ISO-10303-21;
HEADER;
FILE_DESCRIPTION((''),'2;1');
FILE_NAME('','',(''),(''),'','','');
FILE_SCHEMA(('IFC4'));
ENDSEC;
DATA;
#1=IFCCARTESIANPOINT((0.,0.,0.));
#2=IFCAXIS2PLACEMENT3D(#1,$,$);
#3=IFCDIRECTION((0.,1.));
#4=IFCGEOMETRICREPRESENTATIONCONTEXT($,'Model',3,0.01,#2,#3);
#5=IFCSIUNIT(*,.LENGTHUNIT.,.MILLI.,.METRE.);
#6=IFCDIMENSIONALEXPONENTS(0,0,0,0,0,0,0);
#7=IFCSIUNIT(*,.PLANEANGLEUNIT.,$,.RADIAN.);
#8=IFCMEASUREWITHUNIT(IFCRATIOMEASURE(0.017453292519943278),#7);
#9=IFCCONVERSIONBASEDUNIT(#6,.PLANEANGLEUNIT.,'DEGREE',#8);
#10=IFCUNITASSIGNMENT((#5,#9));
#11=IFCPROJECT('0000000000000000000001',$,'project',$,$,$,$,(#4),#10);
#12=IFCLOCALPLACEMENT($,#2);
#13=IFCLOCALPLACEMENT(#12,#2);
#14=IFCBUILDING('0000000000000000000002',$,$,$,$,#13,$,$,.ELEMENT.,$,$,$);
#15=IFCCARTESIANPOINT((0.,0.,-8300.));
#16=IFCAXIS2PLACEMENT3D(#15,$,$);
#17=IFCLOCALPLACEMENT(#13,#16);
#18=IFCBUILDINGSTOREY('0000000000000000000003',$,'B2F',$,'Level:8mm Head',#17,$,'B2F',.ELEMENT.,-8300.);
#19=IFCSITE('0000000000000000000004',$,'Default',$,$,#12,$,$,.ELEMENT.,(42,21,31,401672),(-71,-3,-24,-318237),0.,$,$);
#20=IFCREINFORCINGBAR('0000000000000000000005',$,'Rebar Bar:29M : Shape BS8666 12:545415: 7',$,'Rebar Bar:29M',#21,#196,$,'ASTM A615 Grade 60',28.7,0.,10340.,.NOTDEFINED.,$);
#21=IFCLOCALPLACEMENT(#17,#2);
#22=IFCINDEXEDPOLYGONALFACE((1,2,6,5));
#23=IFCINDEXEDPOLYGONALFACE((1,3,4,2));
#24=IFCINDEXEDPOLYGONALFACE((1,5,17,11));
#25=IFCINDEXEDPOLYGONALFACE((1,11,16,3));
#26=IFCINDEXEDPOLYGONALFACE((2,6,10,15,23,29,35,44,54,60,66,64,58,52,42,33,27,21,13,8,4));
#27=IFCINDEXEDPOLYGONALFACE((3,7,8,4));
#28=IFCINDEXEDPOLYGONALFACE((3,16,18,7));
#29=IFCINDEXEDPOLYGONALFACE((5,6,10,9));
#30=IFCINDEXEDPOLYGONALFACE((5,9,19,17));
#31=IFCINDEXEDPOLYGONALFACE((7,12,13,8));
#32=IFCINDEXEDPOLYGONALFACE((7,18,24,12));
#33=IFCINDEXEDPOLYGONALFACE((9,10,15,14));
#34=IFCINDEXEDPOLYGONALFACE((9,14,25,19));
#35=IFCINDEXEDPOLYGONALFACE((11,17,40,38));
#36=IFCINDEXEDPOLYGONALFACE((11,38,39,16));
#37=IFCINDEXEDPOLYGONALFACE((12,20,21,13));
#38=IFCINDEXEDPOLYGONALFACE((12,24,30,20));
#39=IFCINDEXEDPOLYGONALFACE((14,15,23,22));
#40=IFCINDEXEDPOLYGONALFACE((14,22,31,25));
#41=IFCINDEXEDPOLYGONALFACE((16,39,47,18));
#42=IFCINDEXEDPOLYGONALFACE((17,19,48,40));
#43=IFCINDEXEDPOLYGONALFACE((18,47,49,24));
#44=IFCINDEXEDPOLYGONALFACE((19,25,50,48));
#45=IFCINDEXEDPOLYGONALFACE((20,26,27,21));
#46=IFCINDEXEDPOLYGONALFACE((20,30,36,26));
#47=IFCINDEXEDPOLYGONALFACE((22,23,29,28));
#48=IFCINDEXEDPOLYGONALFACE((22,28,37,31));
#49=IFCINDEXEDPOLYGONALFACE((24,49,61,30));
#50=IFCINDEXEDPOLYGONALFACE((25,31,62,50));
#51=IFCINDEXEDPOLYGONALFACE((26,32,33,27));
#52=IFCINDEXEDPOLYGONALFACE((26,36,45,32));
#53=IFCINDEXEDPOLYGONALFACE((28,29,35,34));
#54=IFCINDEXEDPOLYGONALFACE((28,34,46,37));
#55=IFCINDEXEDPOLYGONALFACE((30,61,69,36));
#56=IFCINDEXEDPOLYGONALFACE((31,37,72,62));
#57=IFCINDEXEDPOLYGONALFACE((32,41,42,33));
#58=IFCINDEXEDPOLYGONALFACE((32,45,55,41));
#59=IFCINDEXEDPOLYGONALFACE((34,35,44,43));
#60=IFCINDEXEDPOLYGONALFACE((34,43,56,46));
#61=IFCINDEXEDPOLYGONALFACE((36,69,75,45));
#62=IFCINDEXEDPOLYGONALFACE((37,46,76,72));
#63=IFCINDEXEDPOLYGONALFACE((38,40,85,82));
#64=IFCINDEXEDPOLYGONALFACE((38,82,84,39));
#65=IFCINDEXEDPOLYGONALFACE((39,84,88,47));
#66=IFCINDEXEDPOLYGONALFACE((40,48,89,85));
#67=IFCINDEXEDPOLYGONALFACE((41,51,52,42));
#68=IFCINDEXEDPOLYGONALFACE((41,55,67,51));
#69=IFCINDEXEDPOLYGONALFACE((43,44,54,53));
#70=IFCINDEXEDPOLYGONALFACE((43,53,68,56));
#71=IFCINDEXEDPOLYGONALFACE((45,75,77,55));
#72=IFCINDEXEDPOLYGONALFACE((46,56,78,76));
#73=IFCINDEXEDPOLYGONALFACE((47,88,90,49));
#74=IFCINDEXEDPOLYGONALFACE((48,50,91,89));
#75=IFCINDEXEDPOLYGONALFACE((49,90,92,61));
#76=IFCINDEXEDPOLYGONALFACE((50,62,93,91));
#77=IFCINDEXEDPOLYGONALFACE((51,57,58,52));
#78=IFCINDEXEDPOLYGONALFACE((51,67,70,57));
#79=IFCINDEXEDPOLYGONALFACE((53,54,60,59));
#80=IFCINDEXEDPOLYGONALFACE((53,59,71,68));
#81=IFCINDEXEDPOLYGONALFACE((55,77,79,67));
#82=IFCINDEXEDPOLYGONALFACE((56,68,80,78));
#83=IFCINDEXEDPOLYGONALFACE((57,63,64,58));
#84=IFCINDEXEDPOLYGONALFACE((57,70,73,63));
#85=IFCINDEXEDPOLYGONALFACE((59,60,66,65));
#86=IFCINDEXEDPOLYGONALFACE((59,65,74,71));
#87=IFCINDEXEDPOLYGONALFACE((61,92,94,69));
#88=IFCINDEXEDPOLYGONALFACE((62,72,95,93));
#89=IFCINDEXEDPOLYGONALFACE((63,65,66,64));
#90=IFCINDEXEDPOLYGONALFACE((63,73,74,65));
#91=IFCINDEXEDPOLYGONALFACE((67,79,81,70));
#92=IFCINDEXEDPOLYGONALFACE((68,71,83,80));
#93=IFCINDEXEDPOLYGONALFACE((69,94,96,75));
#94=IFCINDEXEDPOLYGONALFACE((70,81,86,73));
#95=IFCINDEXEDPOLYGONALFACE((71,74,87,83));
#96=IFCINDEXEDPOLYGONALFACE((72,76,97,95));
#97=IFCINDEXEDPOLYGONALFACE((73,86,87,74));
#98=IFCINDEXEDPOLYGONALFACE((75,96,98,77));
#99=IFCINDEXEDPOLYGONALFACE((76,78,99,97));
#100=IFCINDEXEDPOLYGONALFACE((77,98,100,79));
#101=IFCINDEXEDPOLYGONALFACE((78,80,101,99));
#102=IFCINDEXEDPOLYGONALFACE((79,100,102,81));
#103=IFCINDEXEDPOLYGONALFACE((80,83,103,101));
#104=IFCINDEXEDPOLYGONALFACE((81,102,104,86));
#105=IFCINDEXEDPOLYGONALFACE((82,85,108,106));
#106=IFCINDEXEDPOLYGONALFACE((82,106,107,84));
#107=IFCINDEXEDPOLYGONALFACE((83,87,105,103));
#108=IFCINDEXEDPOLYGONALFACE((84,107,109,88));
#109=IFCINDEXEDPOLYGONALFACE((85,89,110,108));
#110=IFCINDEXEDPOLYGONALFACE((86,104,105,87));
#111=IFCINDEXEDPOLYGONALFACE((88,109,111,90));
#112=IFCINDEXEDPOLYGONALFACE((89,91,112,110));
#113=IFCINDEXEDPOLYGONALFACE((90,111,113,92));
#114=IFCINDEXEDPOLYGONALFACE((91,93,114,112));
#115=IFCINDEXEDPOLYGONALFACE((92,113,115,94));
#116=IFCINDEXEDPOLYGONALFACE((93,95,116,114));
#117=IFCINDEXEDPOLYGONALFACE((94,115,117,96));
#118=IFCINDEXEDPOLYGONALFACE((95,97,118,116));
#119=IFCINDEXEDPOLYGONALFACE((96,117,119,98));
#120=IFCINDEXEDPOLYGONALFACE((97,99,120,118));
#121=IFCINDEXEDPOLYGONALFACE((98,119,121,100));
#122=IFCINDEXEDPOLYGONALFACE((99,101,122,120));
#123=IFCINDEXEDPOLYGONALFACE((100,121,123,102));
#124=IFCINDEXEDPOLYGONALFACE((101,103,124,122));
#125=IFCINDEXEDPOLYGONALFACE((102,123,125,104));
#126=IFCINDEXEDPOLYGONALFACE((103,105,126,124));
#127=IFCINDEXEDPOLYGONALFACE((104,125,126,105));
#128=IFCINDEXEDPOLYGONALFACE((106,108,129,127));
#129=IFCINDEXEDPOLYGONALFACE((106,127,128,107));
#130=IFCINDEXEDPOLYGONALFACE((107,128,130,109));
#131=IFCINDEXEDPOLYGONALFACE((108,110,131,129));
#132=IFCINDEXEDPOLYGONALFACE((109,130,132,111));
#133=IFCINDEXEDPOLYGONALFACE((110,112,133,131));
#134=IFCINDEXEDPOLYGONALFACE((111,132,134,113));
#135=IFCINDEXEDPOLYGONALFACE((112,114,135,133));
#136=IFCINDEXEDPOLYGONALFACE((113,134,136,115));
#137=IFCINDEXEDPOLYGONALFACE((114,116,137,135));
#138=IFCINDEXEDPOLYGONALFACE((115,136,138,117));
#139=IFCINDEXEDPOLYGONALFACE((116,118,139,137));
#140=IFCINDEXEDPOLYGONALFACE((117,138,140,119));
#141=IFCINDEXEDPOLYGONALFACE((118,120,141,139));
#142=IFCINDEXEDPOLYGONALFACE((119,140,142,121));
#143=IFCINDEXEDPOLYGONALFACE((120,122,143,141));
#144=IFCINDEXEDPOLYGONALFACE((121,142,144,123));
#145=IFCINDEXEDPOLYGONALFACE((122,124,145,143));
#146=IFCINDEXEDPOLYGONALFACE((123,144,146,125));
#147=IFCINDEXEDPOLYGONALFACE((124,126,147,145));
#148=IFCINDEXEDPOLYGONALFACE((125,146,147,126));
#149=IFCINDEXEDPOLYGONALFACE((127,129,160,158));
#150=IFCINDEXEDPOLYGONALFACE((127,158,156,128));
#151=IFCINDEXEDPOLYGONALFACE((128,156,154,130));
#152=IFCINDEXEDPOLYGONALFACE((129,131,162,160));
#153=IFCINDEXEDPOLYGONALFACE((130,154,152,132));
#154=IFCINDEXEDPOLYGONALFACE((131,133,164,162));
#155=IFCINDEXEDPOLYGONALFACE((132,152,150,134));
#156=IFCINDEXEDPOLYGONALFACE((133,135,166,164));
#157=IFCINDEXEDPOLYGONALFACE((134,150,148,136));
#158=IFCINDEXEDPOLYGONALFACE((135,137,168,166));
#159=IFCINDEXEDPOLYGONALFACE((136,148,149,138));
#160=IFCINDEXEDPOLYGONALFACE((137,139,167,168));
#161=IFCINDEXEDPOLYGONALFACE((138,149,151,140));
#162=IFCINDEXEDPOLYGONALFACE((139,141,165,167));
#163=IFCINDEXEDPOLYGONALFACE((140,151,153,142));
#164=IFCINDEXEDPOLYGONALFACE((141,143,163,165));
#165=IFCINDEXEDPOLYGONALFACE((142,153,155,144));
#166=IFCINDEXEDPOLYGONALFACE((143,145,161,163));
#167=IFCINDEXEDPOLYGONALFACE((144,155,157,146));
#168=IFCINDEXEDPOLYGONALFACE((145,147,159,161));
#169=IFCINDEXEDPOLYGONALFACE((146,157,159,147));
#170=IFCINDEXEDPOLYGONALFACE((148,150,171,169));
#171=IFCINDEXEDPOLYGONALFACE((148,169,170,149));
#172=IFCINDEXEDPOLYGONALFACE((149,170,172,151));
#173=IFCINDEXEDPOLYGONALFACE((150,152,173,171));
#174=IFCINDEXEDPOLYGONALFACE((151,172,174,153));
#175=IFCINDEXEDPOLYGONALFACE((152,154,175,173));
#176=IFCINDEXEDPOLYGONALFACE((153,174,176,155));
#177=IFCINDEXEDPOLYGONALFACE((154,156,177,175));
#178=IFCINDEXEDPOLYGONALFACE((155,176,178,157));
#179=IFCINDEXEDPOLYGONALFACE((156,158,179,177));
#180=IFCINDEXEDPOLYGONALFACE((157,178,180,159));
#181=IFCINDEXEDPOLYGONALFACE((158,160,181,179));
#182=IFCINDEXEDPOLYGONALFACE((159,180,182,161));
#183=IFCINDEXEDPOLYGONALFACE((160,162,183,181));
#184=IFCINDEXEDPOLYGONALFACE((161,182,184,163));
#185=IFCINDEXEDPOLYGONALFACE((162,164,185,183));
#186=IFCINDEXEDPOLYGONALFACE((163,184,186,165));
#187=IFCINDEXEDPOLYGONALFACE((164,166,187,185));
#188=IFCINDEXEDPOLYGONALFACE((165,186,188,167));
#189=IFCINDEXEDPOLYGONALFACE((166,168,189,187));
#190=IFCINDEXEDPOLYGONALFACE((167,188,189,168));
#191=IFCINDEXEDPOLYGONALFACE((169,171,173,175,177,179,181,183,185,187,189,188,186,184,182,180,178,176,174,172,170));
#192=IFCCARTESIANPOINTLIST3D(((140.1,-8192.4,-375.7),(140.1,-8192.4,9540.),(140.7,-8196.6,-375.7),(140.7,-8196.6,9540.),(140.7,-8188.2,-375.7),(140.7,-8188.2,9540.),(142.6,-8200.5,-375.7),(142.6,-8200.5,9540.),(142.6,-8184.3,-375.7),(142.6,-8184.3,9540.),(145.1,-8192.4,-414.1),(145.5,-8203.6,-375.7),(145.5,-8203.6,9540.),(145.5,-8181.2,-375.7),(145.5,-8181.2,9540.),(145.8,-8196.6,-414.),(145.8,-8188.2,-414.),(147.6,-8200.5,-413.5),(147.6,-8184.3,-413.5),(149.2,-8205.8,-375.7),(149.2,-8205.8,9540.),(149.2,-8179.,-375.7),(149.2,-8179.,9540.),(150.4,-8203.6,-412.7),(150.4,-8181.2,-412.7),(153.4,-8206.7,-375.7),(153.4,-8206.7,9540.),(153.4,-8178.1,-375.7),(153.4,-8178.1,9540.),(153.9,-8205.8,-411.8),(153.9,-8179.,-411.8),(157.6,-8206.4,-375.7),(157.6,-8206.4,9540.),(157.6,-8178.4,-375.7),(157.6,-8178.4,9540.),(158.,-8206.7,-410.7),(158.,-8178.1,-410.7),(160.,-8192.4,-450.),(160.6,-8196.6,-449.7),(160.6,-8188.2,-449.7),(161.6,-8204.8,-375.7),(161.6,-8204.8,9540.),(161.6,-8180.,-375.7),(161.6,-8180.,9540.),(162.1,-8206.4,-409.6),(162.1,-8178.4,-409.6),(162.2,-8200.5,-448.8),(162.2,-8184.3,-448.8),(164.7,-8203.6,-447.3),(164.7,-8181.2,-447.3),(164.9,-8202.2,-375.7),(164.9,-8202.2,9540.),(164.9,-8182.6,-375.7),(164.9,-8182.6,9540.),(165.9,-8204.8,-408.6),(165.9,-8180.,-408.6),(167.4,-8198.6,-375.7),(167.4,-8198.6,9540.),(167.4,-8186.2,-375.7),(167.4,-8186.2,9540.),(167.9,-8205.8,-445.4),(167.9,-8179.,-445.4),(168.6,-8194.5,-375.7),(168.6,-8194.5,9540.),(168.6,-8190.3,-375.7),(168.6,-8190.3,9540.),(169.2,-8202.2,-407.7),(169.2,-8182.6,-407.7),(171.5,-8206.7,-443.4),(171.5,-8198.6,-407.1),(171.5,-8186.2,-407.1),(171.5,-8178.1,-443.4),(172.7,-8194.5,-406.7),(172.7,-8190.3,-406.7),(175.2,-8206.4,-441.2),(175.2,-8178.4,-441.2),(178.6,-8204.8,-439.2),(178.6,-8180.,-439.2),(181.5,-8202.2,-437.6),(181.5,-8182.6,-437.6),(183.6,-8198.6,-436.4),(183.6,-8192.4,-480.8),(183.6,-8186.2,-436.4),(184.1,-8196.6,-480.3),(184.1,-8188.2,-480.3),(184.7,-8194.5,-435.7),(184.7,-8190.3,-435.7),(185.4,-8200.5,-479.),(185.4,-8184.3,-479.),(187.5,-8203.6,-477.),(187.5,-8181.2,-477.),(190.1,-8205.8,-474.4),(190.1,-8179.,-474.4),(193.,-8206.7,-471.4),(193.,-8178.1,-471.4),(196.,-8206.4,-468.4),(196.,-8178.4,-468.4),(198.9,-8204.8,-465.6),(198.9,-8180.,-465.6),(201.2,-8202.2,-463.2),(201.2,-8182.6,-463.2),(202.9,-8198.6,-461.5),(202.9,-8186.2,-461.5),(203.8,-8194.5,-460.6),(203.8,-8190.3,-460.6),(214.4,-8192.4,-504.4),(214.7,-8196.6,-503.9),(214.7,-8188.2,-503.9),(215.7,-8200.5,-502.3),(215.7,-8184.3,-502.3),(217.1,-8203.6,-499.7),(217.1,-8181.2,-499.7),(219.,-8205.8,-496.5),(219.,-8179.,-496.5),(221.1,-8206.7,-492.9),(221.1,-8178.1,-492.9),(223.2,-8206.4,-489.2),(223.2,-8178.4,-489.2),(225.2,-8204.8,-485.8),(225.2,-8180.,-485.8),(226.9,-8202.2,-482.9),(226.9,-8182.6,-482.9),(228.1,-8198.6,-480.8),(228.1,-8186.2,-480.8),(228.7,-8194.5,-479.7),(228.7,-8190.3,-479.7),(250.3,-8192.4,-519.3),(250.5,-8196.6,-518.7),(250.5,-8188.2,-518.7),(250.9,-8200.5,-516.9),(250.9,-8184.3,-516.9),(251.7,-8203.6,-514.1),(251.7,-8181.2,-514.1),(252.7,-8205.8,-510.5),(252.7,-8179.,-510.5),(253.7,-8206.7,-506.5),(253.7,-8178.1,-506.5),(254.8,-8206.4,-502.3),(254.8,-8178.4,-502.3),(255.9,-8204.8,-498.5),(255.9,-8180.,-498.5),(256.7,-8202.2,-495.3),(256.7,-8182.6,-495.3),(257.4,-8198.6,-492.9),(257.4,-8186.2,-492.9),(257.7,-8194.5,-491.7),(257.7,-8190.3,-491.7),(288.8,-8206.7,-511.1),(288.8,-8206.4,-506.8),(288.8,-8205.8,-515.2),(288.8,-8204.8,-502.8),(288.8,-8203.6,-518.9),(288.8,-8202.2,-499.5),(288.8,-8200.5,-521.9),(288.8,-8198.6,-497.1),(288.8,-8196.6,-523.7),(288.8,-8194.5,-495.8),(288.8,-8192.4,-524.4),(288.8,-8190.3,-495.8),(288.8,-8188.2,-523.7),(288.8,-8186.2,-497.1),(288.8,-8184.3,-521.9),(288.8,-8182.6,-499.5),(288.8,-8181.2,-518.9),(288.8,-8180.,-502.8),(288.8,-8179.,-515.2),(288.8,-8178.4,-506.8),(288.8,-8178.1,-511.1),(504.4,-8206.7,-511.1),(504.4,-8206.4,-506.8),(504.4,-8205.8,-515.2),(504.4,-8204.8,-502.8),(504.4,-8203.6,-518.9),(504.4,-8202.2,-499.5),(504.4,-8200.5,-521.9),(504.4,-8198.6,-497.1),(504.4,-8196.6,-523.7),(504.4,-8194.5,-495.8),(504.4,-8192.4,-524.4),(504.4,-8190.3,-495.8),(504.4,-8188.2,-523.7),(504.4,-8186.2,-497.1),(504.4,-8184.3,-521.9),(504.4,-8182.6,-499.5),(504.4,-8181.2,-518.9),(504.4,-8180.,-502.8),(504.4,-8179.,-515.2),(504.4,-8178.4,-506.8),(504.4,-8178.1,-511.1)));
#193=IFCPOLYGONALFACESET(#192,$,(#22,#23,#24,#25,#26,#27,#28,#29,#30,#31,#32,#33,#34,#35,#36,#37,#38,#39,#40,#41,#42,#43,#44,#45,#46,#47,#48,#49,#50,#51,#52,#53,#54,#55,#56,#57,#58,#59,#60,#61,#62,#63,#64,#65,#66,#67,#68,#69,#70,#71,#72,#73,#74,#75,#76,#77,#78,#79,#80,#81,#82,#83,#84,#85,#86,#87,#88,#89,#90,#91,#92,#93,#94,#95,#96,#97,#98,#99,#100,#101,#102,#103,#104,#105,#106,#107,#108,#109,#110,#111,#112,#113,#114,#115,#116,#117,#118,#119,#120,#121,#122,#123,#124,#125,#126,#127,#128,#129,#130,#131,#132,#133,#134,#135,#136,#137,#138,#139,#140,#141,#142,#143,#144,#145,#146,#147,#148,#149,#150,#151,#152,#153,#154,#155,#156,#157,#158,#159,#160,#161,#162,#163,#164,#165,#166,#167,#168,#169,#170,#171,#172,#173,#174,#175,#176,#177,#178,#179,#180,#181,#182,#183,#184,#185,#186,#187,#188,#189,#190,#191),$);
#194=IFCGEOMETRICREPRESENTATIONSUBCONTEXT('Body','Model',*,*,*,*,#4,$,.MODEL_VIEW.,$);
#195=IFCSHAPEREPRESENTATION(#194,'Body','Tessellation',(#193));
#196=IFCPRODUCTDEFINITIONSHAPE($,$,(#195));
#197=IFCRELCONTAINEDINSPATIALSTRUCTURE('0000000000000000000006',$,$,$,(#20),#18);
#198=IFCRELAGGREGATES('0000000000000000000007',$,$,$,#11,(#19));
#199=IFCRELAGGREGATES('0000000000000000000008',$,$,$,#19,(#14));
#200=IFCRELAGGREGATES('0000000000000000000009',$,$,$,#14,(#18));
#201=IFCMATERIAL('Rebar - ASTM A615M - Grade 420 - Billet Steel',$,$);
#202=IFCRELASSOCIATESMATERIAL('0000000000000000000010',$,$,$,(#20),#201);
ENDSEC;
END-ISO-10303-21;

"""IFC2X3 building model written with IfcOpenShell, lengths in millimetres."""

from ifc_helpers import new_model, entity, si_unit, converted_unit, direction, frame, origin, place, context, subcontext, project, spatial, material, element, save


model = new_model("IFC2X3")

# Units and contexts
model_context = context("Model", 3, precision=0.01, world=origin(), true_north=direction((0.0, 1.0)))
body_context = subcontext(model_context, "Body", "Model", "MODEL_VIEW")
ifc_project = project(units=[si_unit("LENGTHUNIT", "METRE", prefix="MILLI"), converted_unit("PLANEANGLEUNIT", "DEGREE", entity("IfcRatioMeasure", 0.017453292519943278), si_unit("PLANEANGLEUNIT", "RADIAN"), dimensions=[0, 0, 0, 0, 0, 0, 0])], contexts=[model_context])

# Site, building, storey
site_placement = place(None, origin())
site = spatial("IfcSite", under=ifc_project, at=site_placement, Name="Default", CompositionType="ELEMENT", RefLatitude=(42, 21, 31, 401672), RefLongitude=(-71, -3, -24, -318237), RefElevation=0.0)
building_placement = place(site_placement, origin())
building = spatial("IfcBuilding", under=site, at=building_placement, CompositionType="ELEMENT")
storey_placement = place(building_placement, frame((0.0, 0.0, -8300.0)))
storey = spatial("IfcBuildingStorey", under=building, at=storey_placement, Name="B2F", ObjectType="Level:8mm Head", LongName="B2F", CompositionType="ELEMENT", Elevation=-8300.0)

# Reinforcing bar
ifc_material_1 = material(Name="Rebar - ASTM A615M - Grade 420 - Billet Steel")
reinforcing_bar_1_placement = place(storey_placement, origin())
element("IfcReinforcingBar", 1, at=reinforcing_bar_1_placement, inside=storey, material=ifc_material_1, Name="Rebar Bar:29M : Shape BS8666 12:545415: 7", SteelGrade="ASTM A615 Grade 60", ObjectType="Rebar Bar:29M", BarLength=10340.0, BarRole="NOTDEFINED", CrossSectionArea=0.0, NominalDiameter=28.7, context=body_context, shape_type="AdvancedSweptSolid", body=[
    entity("IfcSweptDiskSolid", entity("IfcCompositeCurve", [entity("IfcCompositeCurveSegment", "CONTINUOUS", True, entity("IfcPolyline", [entity("IfcCartesianPoint", [154.4, -8192.4, 9540.0]), entity("IfcCartesianPoint", [154.4, -8192.4, -375.7])])), entity("IfcCompositeCurveSegment", "CONTINUOUS", True, entity("IfcTrimmedCurve", entity("IfcCircle", entity("IfcAxis2Placement3D", entity("IfcCartesianPoint", [288.8, -8192.4, -375.7]), entity("IfcDirection", [0.0, -1.0, 0.0]), entity("IfcDirection", [0.0, 0.0, -1.0])), 134.3), [entity("IfcParameterValue", 270.0)], [entity("IfcParameterValue", 360.0)], True, "PARAMETER")), entity("IfcCompositeCurveSegment", "CONTINUOUS", True, entity("IfcPolyline", [entity("IfcCartesianPoint", [288.8, -8192.4, -510.0]), entity("IfcCartesianPoint", [504.4, -8192.4, -510.0])]))], False), 14.3, None, 0.0, 92.0),
])

save(model, "model.ifc")
